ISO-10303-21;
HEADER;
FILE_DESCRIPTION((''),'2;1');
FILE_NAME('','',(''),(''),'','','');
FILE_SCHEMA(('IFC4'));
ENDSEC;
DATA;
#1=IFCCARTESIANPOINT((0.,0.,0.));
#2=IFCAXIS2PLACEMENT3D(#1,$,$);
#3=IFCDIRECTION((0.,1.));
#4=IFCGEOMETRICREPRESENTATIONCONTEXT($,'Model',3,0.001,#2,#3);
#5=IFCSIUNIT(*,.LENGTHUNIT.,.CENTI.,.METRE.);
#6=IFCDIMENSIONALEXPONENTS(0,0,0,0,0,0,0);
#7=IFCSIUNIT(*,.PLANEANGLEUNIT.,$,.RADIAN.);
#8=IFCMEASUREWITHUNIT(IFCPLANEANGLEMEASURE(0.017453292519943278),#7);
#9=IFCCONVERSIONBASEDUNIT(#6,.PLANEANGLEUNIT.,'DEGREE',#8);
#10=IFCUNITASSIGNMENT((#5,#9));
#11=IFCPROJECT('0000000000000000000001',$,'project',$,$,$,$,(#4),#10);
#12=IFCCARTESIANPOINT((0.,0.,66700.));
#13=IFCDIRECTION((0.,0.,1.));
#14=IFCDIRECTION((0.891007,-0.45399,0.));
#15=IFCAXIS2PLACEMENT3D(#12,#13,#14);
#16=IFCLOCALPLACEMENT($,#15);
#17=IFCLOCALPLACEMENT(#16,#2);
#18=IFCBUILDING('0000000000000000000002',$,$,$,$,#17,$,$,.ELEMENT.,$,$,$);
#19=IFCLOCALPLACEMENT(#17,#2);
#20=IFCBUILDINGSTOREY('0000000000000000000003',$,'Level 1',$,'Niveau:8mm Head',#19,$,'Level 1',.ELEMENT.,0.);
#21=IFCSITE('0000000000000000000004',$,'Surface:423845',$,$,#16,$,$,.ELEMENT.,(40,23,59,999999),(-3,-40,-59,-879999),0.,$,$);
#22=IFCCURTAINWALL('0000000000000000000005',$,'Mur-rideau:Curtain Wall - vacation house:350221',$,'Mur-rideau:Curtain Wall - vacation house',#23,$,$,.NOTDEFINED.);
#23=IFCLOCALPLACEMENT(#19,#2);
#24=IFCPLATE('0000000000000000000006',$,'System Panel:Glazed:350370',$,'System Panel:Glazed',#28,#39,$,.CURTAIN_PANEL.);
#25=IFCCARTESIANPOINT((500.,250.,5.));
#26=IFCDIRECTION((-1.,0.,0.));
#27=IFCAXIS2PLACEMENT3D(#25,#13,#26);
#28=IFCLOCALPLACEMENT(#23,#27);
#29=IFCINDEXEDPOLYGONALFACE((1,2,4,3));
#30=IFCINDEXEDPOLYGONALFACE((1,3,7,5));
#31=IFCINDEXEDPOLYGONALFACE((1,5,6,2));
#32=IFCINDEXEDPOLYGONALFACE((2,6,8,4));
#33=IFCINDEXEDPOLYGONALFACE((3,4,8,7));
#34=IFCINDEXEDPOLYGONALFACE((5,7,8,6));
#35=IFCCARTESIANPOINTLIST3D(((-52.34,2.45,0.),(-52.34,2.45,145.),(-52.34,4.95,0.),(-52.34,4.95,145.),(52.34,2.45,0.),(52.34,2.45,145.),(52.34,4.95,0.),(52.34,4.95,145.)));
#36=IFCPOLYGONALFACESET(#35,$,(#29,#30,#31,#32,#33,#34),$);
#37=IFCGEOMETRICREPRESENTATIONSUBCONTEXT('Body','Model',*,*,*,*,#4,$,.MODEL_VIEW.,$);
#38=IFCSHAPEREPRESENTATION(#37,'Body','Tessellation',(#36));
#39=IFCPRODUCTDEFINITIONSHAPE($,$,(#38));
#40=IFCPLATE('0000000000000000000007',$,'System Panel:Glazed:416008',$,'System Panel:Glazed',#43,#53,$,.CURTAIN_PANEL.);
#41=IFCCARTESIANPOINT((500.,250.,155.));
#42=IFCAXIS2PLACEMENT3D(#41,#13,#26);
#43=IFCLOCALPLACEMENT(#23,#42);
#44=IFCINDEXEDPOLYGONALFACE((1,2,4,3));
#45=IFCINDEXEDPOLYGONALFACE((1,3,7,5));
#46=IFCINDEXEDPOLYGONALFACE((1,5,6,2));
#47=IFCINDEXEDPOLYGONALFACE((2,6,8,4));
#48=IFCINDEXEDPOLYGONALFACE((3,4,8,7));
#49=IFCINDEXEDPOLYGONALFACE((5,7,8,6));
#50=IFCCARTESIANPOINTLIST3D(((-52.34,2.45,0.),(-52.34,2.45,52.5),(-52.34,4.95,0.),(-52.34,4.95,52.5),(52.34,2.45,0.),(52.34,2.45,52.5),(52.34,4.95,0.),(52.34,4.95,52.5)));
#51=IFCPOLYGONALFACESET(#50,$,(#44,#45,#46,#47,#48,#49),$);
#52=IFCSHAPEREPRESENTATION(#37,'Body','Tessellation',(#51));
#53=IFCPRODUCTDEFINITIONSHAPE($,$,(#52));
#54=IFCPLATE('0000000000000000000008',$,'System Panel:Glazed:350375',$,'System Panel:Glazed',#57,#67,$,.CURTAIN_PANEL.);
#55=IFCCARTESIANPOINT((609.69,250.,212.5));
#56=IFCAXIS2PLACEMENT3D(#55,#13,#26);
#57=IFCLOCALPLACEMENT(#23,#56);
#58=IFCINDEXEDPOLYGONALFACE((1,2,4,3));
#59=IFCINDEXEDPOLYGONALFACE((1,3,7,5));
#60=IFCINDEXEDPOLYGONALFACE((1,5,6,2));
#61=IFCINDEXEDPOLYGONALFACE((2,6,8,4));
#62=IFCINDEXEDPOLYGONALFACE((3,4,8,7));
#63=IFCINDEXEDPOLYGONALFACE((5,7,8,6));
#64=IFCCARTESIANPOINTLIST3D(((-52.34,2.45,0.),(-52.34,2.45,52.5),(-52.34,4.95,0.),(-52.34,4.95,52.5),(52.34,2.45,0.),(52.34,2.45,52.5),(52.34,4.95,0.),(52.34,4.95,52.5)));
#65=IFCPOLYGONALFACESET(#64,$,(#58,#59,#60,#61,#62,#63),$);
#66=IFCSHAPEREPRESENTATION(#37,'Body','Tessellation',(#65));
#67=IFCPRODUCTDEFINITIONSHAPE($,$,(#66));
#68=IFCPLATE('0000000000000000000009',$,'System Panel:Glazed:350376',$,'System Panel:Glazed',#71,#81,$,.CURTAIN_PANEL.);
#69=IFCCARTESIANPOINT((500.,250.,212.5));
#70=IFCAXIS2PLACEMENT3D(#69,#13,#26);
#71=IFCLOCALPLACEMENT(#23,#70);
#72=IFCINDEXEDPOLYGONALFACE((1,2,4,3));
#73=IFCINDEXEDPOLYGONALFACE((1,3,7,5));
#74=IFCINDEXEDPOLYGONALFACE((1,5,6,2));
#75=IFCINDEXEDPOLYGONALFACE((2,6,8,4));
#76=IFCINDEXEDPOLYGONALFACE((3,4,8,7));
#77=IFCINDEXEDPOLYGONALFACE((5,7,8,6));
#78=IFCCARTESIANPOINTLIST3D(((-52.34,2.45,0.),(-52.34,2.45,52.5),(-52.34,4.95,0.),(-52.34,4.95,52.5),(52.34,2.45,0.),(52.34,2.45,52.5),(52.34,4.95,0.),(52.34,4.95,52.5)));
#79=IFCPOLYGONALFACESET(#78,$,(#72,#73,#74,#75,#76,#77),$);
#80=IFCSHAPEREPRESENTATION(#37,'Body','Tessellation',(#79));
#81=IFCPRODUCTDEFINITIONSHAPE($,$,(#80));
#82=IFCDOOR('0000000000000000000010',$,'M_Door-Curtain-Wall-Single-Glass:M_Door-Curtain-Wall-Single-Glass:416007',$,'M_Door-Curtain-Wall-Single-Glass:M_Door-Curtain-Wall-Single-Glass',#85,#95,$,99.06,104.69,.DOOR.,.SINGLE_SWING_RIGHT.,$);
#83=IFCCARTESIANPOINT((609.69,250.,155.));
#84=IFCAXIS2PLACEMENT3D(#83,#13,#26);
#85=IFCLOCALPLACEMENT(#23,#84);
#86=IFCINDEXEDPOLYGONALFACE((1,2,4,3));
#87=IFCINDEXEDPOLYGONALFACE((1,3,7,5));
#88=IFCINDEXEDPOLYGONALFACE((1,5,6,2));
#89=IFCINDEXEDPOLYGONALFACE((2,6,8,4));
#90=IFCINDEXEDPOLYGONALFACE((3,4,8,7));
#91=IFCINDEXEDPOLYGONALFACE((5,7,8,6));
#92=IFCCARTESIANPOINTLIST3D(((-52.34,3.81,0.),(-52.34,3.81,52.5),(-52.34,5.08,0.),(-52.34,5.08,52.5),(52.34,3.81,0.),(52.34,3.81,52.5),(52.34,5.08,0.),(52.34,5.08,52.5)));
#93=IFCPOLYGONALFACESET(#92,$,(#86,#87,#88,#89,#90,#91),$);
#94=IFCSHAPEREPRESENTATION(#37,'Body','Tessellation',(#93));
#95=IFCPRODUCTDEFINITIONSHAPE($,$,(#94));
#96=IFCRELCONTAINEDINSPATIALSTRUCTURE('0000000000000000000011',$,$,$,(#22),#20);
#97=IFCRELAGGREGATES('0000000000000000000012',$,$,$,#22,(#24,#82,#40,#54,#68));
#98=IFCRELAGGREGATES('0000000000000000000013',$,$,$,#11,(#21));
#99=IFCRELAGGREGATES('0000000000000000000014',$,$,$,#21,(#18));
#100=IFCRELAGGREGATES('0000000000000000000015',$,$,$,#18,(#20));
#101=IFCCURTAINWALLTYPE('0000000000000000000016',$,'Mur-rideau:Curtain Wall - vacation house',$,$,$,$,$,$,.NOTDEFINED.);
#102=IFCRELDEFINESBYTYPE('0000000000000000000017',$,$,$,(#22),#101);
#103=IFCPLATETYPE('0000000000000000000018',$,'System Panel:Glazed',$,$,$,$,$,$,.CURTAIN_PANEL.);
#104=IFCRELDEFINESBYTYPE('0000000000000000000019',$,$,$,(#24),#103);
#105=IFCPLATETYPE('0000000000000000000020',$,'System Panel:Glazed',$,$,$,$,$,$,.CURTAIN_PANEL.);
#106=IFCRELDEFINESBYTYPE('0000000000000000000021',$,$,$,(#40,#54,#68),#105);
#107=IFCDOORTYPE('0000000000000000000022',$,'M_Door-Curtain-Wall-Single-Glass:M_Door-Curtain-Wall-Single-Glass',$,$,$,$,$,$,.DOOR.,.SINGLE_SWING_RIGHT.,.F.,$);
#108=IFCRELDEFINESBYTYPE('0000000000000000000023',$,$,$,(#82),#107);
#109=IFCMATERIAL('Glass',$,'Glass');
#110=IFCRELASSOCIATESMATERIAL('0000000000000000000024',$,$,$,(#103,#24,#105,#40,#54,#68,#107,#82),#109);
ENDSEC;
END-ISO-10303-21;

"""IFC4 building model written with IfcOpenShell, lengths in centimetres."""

from ifc_helpers import new_model, entity, si_unit, converted_unit, direction, frame, frame_2d, origin, origin_2d_with_axis, place, context, subcontext, project, spatial, rectangle, extrude, source, transform, mapped, material, type_object, type_shapes, element, aggregate, save


model = new_model("IFC4")

# Units and contexts
model_context = context("Model", 3, precision=0.001, world=origin(), true_north=direction((0.0, 1.0)))
body_context = subcontext(model_context, "Body", "Model", "MODEL_VIEW")
ifc_project = project(units=[si_unit("LENGTHUNIT", "METRE", prefix="CENTI"), converted_unit("PLANEANGLEUNIT", "DEGREE", entity("IfcPlaneAngleMeasure", 0.017453292519943278), si_unit("PLANEANGLEUNIT", "RADIAN"), dimensions=[0, 0, 0, 0, 0, 0, 0])], contexts=[model_context])

# Site, building, storey
site_placement = place(None, frame((0.0, 0.0, 66700.0), z_axis=(0.0, 0.0, 1.0), x_axis=(0.891007, -0.45399, 0.0)))
site = spatial("IfcSite", under=ifc_project, at=site_placement, Name="Surface:423845", CompositionType="ELEMENT", RefLatitude=(40, 23, 59, 999999), RefLongitude=(-3, -40, -59, -879999), RefElevation=0.0)
building_placement = place(site_placement, origin())
building = spatial("IfcBuilding", under=site, at=building_placement, CompositionType="ELEMENT")
storey_placement = place(building_placement, origin())
storey = spatial("IfcBuildingStorey", under=building, at=storey_placement, Name="Level 1", ObjectType="Niveau:8mm Head", LongName="Level 1", CompositionType="ELEMENT", Elevation=0.0)

# Curtain wall
curtain_wall_type = type_object("IfcCurtainWallType", Name="Mur-rideau:Curtain Wall - vacation house", PredefinedType="NOTDEFINED")
curtain_wall_placement = place(storey_placement, origin())
curtain_wall = element("IfcCurtainWall", 1, at=curtain_wall_placement, inside=storey, type_object=curtain_wall_type, Name="Mur-rideau:Curtain Wall - vacation house:350221", ObjectType="Mur-rideau:Curtain Wall - vacation house", PredefinedType="NOTDEFINED")

# Plates
ifc_material_1 = material(Name="Glass", Category="Glass")
plate_type_1 = type_object("IfcPlateType", Name="System Panel:Glazed", PredefinedType="CURTAIN_PANEL", material=ifc_material_1)
shared_shape_1 = source(origin(), body_context, "Body", "SweptSolid", [
    extrude(rectangle(XDim=2.5, YDim=104.69, at=origin_2d_with_axis()), frame((0.0, 3.7, 0.0), z_axis=(0.0, 0.0, 1.0), x_axis=(0.0, 1.0, 0.0)), (0.0, 0.0, 1.0), 145.0),
])
type_shapes(plate_type_1, [shared_shape_1])
plate_1_placement = place(curtain_wall_placement, frame((500.0, 250.0, 5.0), z_axis=(0.0, 0.0, 1.0), x_axis=(-1.0, 0.0, 0.0)))
plate_1 = element("IfcPlate", 2, at=plate_1_placement, type_object=plate_type_1, material=ifc_material_1, Name="System Panel:Glazed:350370", ObjectType="System Panel:Glazed", PredefinedType="CURTAIN_PANEL", context=body_context, shape_type="MappedRepresentation", body=[
    mapped(shared_shape_1, transform((0.0, 0.0, 0.0), scale=1.0)),
])
plate_type_2 = type_object("IfcPlateType", Name="System Panel:Glazed", PredefinedType="CURTAIN_PANEL", material=ifc_material_1)
shared_shape_2 = source(origin(), body_context, "Body", "SweptSolid", [
    extrude(rectangle(XDim=2.5, YDim=104.69, at=origin_2d_with_axis()), frame((0.0, 3.7, 0.0), z_axis=(0.0, 0.0, 1.0), x_axis=(0.0, 1.0, 0.0)), (0.0, 0.0, 1.0), 52.5),
])
type_shapes(plate_type_2, [shared_shape_2])
plate_2_placement = place(curtain_wall_placement, frame((500.0, 250.0, 155.0), z_axis=(0.0, 0.0, 1.0), x_axis=(-1.0, 0.0, 0.0)))
plate_2 = element("IfcPlate", 3, at=plate_2_placement, type_object=plate_type_2, material=ifc_material_1, Name="System Panel:Glazed:416008", ObjectType="System Panel:Glazed", PredefinedType="CURTAIN_PANEL", context=body_context, shape_type="MappedRepresentation", body=[
    mapped(shared_shape_2, transform((0.0, 0.0, 0.0), scale=1.0)),
])
plate_3_placement = place(curtain_wall_placement, frame((609.69, 250.0, 212.5), z_axis=(0.0, 0.0, 1.0), x_axis=(-1.0, 0.0, 0.0)))
plate_3 = element("IfcPlate", 4, at=plate_3_placement, type_object=plate_type_2, material=ifc_material_1, Name="System Panel:Glazed:350375", ObjectType="System Panel:Glazed", PredefinedType="CURTAIN_PANEL", context=body_context, shape_type="MappedRepresentation", body=[
    mapped(shared_shape_2, transform((0.0, 0.0, 0.0), scale=1.0)),
])
plate_4_placement = place(curtain_wall_placement, frame((500.0, 250.0, 212.5), z_axis=(0.0, 0.0, 1.0), x_axis=(-1.0, 0.0, 0.0)))
plate_4 = element("IfcPlate", 5, at=plate_4_placement, type_object=plate_type_2, material=ifc_material_1, Name="System Panel:Glazed:350376", ObjectType="System Panel:Glazed", PredefinedType="CURTAIN_PANEL", context=body_context, shape_type="MappedRepresentation", body=[
    mapped(shared_shape_2, transform((0.0, 0.0, 0.0), scale=1.0)),
])

# Door
door_type_1 = type_object("IfcDoorType", Name="M_Door-Curtain-Wall-Single-Glass:M_Door-Curtain-Wall-Single-Glass", OperationType="SINGLE_SWING_RIGHT", ParameterTakesPrecedence=False, PredefinedType="DOOR", material=ifc_material_1)
shared_shape_3 = source(origin(), body_context, "Body", "SweptSolid", [
    extrude(rectangle(XDim=104.69, YDim=1.27, at=frame_2d((0.0, 0.0), x_axis=(1.0, 0.0))), frame((0.0, 4.45, 0.0), z_axis=(0.0, 0.0, 1.0), x_axis=(-1.0, 0.0, 0.0)), (0.0, 0.0, 1.0), 52.5),
])
type_shapes(door_type_1, [shared_shape_3])
door_1_placement = place(curtain_wall_placement, frame((609.69, 250.0, 155.0), z_axis=(0.0, 0.0, 1.0), x_axis=(-1.0, 0.0, 0.0)))
door_1 = element("IfcDoor", 6, at=door_1_placement, type_object=door_type_1, material=ifc_material_1, Name="M_Door-Curtain-Wall-Single-Glass:M_Door-Curtain-Wall-Single-Glass:416007", ObjectType="M_Door-Curtain-Wall-Single-Glass:M_Door-Curtain-Wall-Single-Glass", OperationType="SINGLE_SWING_RIGHT", OverallHeight=99.06, OverallWidth=104.69, PredefinedType="DOOR", context=body_context, shape_type="MappedRepresentation", body=[
    mapped(shared_shape_3, transform((0.0, 0.0, 0.0), scale=1.0)),
])
aggregate(curtain_wall, [plate_1, door_1, plate_2, plate_3, plate_4])

save(model, "model.ifc")
